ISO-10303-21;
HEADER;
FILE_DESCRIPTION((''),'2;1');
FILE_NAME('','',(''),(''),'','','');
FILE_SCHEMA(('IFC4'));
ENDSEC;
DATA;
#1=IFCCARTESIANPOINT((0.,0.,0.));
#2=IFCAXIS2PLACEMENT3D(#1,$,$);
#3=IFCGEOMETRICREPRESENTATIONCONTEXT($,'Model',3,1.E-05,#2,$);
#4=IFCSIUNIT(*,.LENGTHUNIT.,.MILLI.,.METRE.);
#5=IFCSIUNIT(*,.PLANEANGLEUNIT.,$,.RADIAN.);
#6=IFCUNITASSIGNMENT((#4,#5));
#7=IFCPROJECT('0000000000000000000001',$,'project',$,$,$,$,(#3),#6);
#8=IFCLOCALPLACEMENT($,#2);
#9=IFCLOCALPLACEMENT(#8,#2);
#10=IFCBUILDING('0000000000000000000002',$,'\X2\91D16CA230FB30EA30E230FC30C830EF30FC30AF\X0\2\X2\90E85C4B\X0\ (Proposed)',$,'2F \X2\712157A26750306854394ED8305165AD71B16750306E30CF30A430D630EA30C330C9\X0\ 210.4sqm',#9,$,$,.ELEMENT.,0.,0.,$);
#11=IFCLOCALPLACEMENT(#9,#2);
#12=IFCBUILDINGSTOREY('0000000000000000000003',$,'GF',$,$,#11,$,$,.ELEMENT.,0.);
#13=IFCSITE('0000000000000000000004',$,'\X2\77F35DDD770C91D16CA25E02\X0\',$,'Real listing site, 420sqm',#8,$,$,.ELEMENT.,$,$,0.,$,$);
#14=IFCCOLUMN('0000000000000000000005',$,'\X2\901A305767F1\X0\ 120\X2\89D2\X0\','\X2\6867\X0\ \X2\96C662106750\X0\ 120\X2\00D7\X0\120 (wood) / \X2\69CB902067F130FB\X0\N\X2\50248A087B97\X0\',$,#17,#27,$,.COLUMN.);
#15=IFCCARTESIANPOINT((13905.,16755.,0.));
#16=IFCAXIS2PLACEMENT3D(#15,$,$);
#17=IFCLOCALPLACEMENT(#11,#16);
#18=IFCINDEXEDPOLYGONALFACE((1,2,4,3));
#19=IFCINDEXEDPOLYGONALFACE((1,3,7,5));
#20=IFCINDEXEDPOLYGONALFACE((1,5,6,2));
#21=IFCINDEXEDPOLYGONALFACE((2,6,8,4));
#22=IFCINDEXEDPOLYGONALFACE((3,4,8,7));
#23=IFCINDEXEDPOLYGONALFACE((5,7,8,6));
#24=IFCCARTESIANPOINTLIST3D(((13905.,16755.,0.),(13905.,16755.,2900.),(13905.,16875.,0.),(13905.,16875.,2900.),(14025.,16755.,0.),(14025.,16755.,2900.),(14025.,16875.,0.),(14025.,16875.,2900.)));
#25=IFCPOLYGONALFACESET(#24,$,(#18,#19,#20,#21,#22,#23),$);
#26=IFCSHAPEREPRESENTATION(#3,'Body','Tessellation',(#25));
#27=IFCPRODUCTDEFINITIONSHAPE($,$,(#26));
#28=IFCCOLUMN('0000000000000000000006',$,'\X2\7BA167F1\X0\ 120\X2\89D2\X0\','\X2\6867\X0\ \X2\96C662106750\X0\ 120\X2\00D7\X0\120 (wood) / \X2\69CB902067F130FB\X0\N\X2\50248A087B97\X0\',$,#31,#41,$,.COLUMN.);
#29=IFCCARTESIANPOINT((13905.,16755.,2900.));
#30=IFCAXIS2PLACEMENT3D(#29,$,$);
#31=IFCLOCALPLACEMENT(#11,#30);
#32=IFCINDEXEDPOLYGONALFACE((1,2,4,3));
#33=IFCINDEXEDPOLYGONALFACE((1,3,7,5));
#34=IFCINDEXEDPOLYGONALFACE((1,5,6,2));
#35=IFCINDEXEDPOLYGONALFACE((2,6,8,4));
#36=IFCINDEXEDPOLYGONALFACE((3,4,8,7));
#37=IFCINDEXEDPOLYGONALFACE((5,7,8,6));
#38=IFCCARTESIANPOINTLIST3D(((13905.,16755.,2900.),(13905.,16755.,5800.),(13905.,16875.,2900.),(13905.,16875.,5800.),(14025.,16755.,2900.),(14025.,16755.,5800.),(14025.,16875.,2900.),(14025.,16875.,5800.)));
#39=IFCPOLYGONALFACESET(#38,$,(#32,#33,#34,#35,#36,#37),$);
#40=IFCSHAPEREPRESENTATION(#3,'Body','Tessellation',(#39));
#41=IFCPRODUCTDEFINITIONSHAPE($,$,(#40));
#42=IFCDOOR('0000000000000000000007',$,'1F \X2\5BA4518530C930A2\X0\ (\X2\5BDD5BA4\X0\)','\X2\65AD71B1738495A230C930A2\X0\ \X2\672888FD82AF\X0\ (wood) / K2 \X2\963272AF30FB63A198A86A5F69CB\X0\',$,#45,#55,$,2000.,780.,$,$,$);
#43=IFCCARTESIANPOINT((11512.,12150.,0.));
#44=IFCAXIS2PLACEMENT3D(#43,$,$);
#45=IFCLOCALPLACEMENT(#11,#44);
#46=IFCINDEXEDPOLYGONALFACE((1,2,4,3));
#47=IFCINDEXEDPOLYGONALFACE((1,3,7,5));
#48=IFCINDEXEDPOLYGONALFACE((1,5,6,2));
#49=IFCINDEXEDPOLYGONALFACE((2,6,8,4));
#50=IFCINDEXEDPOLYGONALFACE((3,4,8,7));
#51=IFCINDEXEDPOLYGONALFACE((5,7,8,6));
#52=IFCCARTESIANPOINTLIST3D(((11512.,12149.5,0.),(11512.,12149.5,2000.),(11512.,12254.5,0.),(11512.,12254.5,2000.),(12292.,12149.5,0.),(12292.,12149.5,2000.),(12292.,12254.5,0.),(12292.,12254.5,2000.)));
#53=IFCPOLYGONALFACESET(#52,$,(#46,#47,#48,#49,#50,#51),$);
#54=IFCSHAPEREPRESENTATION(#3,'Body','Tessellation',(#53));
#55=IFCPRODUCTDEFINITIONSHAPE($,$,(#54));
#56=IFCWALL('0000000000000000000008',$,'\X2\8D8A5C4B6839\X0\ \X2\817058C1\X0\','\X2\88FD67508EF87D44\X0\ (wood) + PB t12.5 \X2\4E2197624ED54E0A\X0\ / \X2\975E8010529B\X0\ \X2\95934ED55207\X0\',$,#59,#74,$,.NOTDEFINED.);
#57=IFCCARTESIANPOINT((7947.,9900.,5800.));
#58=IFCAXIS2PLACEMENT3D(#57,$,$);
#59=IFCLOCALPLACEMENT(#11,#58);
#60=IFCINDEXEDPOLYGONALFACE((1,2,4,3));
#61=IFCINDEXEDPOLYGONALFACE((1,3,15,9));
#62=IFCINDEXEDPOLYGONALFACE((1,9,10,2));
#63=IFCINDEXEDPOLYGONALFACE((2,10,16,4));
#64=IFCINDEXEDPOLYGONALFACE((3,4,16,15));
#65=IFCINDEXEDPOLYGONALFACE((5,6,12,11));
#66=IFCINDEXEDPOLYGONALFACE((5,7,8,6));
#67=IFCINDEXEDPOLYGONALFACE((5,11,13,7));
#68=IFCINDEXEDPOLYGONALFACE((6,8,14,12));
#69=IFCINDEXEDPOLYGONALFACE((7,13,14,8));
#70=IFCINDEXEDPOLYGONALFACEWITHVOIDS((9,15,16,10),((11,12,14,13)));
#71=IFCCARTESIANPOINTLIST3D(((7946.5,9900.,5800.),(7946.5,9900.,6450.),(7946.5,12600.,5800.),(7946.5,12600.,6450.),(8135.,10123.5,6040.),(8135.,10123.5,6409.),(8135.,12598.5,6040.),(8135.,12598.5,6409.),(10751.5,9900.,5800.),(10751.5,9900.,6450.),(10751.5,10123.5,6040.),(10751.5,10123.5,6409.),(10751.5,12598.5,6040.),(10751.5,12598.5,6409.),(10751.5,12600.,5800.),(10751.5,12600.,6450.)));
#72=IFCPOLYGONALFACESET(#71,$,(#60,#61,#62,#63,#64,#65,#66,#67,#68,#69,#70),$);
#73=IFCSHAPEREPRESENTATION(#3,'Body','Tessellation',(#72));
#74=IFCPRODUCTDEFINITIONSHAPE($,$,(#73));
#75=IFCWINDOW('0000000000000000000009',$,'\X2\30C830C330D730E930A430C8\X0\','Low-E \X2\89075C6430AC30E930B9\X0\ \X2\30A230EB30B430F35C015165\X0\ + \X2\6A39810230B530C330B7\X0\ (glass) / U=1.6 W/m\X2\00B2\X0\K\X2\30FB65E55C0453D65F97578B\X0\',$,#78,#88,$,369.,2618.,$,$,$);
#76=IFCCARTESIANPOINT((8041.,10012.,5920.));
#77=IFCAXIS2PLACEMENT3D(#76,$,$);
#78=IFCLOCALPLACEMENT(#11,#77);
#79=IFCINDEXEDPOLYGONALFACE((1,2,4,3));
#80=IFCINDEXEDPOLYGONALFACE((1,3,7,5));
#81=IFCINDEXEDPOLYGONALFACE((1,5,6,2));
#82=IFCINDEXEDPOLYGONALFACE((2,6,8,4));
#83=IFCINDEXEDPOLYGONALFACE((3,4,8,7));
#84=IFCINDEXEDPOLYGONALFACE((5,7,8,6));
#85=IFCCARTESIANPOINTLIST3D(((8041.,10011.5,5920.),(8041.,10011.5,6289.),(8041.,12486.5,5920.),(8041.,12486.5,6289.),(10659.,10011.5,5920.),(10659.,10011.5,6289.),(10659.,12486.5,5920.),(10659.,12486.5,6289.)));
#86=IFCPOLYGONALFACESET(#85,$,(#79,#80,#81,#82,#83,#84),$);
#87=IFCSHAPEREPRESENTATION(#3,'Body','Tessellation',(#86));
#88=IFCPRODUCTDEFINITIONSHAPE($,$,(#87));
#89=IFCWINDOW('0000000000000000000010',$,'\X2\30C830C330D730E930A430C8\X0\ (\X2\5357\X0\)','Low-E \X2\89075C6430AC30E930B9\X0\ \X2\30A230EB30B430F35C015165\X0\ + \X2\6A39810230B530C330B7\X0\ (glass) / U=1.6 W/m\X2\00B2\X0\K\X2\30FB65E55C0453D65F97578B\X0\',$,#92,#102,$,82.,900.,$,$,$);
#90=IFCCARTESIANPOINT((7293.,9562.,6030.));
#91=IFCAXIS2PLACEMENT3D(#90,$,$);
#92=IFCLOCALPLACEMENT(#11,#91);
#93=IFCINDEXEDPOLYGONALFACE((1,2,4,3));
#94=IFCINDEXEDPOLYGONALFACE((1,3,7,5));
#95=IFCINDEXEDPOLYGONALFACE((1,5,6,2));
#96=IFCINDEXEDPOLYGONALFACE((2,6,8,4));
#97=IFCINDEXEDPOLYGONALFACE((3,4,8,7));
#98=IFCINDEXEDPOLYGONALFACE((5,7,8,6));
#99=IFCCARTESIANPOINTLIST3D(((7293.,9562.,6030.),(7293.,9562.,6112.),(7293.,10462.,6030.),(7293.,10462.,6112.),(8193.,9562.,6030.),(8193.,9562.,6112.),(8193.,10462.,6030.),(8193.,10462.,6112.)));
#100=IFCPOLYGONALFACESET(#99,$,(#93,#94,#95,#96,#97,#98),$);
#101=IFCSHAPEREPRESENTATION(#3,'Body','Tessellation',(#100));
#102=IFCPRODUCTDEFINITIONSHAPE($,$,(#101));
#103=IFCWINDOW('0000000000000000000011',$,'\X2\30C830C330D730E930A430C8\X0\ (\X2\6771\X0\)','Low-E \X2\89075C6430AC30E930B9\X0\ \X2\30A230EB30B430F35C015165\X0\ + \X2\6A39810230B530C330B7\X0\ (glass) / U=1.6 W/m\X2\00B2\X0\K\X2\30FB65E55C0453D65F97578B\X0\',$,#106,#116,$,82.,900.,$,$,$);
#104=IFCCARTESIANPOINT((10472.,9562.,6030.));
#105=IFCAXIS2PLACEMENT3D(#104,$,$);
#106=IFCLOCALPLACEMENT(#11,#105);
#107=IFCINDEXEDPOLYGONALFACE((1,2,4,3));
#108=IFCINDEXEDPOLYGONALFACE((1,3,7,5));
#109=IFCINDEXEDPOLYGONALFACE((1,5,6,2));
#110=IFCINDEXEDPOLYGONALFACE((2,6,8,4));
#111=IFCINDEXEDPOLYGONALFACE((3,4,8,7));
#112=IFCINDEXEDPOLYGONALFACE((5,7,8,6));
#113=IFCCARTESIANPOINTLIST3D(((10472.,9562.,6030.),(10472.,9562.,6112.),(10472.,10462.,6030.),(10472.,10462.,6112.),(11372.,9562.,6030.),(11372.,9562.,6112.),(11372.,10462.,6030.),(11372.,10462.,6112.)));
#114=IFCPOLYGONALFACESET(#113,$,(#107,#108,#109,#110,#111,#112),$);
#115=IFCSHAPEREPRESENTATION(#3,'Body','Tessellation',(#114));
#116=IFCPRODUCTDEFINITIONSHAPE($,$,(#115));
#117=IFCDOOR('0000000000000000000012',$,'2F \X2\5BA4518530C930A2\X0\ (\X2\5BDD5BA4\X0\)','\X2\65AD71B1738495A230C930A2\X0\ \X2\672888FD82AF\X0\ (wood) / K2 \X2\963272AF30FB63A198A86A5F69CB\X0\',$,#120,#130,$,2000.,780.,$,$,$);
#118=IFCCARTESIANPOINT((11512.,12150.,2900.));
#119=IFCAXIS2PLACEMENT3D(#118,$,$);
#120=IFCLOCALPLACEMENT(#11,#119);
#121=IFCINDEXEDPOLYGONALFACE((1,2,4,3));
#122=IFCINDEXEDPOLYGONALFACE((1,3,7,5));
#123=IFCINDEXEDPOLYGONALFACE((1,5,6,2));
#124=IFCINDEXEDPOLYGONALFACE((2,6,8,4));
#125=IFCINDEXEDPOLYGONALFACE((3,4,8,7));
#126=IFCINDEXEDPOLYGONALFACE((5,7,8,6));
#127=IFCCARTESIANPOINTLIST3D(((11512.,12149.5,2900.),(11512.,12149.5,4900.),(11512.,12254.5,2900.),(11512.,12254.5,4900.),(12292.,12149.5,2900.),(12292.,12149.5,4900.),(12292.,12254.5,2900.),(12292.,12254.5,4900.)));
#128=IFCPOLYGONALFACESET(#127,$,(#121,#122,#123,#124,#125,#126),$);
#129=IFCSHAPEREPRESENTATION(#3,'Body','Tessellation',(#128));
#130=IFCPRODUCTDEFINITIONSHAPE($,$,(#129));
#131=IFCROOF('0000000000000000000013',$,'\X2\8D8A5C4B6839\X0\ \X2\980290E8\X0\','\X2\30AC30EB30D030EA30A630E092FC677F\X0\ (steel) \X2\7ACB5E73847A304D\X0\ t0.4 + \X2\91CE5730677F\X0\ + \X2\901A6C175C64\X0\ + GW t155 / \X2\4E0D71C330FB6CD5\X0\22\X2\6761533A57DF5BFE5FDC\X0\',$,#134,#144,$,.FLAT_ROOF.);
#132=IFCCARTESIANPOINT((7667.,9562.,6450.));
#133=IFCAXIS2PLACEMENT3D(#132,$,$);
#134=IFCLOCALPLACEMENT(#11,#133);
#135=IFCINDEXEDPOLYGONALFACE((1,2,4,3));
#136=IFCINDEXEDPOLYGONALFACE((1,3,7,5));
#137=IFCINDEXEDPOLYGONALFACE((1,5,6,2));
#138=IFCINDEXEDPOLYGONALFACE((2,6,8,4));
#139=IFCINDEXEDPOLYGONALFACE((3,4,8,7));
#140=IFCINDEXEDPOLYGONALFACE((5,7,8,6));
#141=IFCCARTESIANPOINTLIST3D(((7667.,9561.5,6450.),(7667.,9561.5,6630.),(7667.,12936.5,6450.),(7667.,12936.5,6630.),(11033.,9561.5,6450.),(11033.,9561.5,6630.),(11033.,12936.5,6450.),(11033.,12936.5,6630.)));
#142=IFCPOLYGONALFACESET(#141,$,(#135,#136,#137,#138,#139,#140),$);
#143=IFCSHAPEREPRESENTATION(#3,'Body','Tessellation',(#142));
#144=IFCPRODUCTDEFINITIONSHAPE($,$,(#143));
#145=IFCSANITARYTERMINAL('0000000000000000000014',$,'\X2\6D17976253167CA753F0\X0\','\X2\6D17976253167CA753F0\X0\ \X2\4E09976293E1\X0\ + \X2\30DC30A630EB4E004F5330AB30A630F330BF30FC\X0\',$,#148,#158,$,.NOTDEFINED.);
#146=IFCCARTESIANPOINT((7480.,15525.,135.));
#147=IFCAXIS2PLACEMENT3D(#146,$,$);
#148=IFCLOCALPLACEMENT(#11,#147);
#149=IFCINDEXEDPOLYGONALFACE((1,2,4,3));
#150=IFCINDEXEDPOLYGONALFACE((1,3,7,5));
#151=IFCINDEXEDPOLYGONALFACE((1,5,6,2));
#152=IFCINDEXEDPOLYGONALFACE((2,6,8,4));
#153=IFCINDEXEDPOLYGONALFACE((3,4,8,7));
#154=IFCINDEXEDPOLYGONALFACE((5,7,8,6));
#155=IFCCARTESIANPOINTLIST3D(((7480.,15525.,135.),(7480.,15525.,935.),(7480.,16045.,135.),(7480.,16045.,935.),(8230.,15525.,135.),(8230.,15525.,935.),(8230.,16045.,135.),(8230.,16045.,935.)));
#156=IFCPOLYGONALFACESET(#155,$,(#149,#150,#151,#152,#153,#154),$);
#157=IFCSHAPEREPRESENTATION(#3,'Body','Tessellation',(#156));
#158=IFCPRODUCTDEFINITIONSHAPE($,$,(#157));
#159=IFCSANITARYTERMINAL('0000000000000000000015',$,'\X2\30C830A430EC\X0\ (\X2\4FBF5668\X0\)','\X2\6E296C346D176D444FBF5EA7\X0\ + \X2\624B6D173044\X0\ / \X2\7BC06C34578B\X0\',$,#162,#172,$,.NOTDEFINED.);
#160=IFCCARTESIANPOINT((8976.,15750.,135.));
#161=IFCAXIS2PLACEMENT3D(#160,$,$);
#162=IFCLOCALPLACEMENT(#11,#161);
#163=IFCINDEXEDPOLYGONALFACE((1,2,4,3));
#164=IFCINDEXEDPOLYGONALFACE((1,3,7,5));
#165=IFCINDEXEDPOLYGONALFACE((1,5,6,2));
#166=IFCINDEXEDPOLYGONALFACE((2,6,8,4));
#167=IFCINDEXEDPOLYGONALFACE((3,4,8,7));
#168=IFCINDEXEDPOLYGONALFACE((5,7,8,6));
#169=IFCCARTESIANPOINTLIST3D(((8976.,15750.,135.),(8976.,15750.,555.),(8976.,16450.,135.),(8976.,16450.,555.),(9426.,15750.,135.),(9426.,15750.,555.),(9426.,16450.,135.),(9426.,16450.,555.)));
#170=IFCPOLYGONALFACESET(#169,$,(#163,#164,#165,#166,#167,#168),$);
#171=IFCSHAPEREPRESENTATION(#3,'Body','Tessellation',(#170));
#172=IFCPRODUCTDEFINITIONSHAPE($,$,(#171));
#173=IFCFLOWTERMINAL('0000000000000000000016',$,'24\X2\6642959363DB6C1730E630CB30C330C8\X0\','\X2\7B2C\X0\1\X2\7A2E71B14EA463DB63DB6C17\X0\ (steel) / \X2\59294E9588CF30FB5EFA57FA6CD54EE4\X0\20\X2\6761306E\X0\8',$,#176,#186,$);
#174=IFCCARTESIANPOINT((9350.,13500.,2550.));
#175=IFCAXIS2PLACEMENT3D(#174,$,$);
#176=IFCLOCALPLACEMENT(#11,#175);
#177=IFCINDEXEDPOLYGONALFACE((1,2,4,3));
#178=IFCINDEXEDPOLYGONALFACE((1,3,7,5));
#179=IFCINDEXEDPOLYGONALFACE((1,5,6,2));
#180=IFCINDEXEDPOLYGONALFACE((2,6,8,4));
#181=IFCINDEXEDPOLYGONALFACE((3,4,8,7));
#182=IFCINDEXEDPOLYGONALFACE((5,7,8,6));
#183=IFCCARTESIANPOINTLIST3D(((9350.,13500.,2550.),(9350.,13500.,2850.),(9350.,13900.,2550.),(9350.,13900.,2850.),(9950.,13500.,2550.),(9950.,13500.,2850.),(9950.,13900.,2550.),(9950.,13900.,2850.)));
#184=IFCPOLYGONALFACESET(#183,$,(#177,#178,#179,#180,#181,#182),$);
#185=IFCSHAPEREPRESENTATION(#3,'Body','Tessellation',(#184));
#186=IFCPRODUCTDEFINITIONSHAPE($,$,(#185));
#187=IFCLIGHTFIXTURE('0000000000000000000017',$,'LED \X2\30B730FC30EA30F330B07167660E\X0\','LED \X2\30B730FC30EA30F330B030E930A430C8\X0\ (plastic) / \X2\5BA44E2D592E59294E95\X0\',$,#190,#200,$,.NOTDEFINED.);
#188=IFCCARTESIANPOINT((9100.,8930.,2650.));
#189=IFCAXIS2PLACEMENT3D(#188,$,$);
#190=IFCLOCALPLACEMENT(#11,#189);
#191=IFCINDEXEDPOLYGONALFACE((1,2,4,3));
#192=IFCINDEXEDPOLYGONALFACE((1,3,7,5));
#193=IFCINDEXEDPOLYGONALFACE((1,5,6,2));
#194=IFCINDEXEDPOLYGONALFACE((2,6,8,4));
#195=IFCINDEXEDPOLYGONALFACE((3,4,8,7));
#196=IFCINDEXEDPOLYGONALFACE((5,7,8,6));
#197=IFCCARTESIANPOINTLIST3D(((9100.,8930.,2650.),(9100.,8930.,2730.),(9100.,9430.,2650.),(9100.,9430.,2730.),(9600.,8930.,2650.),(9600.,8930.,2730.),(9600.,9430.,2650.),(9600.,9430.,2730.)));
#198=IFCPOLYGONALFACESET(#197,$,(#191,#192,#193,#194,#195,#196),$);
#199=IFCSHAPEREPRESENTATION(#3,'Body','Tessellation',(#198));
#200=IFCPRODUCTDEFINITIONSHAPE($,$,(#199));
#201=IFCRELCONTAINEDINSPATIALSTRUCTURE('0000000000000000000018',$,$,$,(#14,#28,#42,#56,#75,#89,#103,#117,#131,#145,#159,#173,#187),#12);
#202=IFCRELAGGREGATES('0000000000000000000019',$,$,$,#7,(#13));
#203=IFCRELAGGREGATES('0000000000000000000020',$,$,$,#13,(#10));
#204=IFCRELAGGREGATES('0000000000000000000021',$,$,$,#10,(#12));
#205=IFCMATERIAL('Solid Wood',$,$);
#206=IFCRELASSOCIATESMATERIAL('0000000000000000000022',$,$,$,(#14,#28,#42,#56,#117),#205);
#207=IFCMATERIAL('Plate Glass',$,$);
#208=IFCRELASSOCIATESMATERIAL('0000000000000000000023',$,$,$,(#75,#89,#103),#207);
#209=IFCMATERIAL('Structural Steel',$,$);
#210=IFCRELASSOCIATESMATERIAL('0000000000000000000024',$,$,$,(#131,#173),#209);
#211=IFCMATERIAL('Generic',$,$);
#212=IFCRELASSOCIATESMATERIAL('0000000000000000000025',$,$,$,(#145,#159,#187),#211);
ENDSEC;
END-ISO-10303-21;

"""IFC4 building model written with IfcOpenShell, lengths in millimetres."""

from ifc_helpers import new_model, si_unit, frame, frame_2d, origin, place, context, project, spatial, rectangle, extrude, material, element, fill, save


model = new_model("IFC4")

# Units and contexts
model_context = context("Model", 3, precision=1e-05, world=origin())
ifc_project = project(units=[si_unit("LENGTHUNIT", "METRE", prefix="MILLI"), si_unit("PLANEANGLEUNIT", "RADIAN")], contexts=[model_context])

# Site, building, storey
site_placement = place(None, origin())
site = spatial("IfcSite", under=ifc_project, at=site_placement, Name="石川県金沢市", ObjectType="Real listing site, 420sqm", CompositionType="ELEMENT", RefElevation=0.0)
building_placement = place(site_placement, origin())
building = spatial("IfcBuilding", under=site, at=building_placement, Name="金沢・リモートワーク2部屋 (Proposed)", ObjectType="2F 無垢材と吹付け断熱材のハイブリッド 210.4sqm", CompositionType="ELEMENT", ElevationOfRefHeight=0.0, ElevationOfTerrain=0.0)
storey_placement = place(building_placement, origin())
storey = spatial("IfcBuildingStorey", under=building, at=storey_placement, Name="GF", CompositionType="ELEMENT", Elevation=0.0)

# Columns
ifc_material_1 = material(Name="Solid Wood")
column_1_placement = place(storey_placement, frame((13905.0, 16755.0, 0.0)))
element("IfcColumn", 1, at=column_1_placement, inside=storey, material=ifc_material_1, Name="通し柱 120角", Description="桧 集成材 120×120 (wood) / 構造柱・N値計算", PredefinedType="COLUMN", context=model_context, shape_type="SweptSolid", body=[
    extrude(rectangle(XDim=120.0, YDim=120.0, at=frame_2d((60.0, 60.0))), frame((13905.0, 16755.0, 0.0)), (0.0, 0.0, 1.0), 2900.0),
])
column_2_placement = place(storey_placement, frame((13905.0, 16755.0, 2900.0)))
element("IfcColumn", 2, at=column_2_placement, inside=storey, material=ifc_material_1, Name="管柱 120角", Description="桧 集成材 120×120 (wood) / 構造柱・N値計算", PredefinedType="COLUMN", context=model_context, shape_type="SweptSolid", body=[
    extrude(rectangle(XDim=120.0, YDim=120.0, at=frame_2d((60.0, 60.0))), frame((13905.0, 16755.0, 2900.0)), (0.0, 0.0, 1.0), 2900.0),
])

# Door
door_1_placement = place(storey_placement, frame((11512.0, 12150.0, 0.0)))
element("IfcDoor", 3, at=door_1_placement, inside=storey, material=ifc_material_1, Name="1F 室内ドア (寝室)", Description="断熱玄関ドア 木製芯 (wood) / K2 防犯・採風機構", OverallHeight=2000.0, OverallWidth=780.0, context=model_context, shape_type="SweptSolid", body=[
    extrude(rectangle(XDim=780.0, YDim=105.0, at=frame_2d((390.0, 52.0))), frame((11512.0, 12150.0, 0.0)), (0.0, 0.0, 1.0), 2000.0),
])

# Wall, openings, windows
wall_1_placement = place(storey_placement, frame((7947.0, 9900.0, 5800.0)))
wall_1 = element("IfcWall", 4, at=wall_1_placement, inside=storey, material=ifc_material_1, Name="越屋根 腰壁", Description="製材軸組 (wood) + PB t12.5 両面仕上 / 非耐力 間仕切", PredefinedType="NOTDEFINED", context=model_context, shape_type="SweptSolid", body=[
    extrude(rectangle(XDim=2805.0, YDim=2700.0, at=frame_2d((1402.0, 1350.0))), frame((7947.0, 9900.0, 5800.0)), (0.0, 0.0, 1.0), 650.0),
])
opening_1_placement = place(storey_placement, frame((8041.0, 10012.0, 5920.0)))
opening_1 = element("IfcOpeningElement", 5, at=opening_1_placement, cuts=wall_1, PredefinedType="NOTDEFINED", context=model_context, shape_type="SweptSolid", body=[
    extrude(rectangle(XDim=2618.0, YDim=2475.0, at=frame_2d((1309.0, 1237.0))), frame((8041.0, 10012.0, 5920.0)), (0.0, 0.0, 1.0), 369.0),
])
opening_2_placement = place(storey_placement, frame((7293.0, 9562.0, 6030.0)))
opening_2 = element("IfcOpeningElement", 6, at=opening_2_placement, cuts=wall_1, PredefinedType="NOTDEFINED", context=model_context, shape_type="SweptSolid", body=[
    extrude(rectangle(XDim=900.0, YDim=900.0, at=frame_2d((450.0, 450.0))), frame((7293.0, 9562.0, 6030.0)), (0.0, 0.0, 1.0), 82.0),
])
opening_3_placement = place(storey_placement, frame((10472.0, 9562.0, 6030.0)))
opening_3 = element("IfcOpeningElement", 7, at=opening_3_placement, cuts=wall_1, PredefinedType="NOTDEFINED", context=model_context, shape_type="SweptSolid", body=[
    extrude(rectangle(XDim=900.0, YDim=900.0, at=frame_2d((450.0, 450.0))), frame((10472.0, 9562.0, 6030.0)), (0.0, 0.0, 1.0), 82.0),
])
ifc_material_2 = material(Name="Plate Glass")
window_1_placement = place(storey_placement, frame((8041.0, 10012.0, 5920.0)))
window_1 = element("IfcWindow", 8, at=window_1_placement, inside=storey, material=ifc_material_2, Name="トップライト", Description="Low-E 複層ガラス アルゴン封入 + 樹脂サッシ (glass) / U=1.6 W/m²K・日射取得型", OverallHeight=369.0, OverallWidth=2618.0, context=model_context, shape_type="SweptSolid", body=[
    extrude(rectangle(XDim=2618.0, YDim=2475.0, at=frame_2d((1309.0, 1237.0))), frame((8041.0, 10012.0, 5920.0)), (0.0, 0.0, 1.0), 369.0),
])
fill(opening_1, window_1)
window_2_placement = place(storey_placement, frame((7293.0, 9562.0, 6030.0)))
window_2 = element("IfcWindow", 9, at=window_2_placement, inside=storey, material=ifc_material_2, Name="トップライト (南)", Description="Low-E 複層ガラス アルゴン封入 + 樹脂サッシ (glass) / U=1.6 W/m²K・日射取得型", OverallHeight=82.0, OverallWidth=900.0, context=model_context, shape_type="SweptSolid", body=[
    extrude(rectangle(XDim=900.0, YDim=900.0, at=frame_2d((450.0, 450.0))), frame((7293.0, 9562.0, 6030.0)), (0.0, 0.0, 1.0), 82.0),
])
fill(opening_2, window_2)
window_3_placement = place(storey_placement, frame((10472.0, 9562.0, 6030.0)))
window_3 = element("IfcWindow", 10, at=window_3_placement, inside=storey, material=ifc_material_2, Name="トップライト (東)", Description="Low-E 複層ガラス アルゴン封入 + 樹脂サッシ (glass) / U=1.6 W/m²K・日射取得型", OverallHeight=82.0, OverallWidth=900.0, context=model_context, shape_type="SweptSolid", body=[
    extrude(rectangle(XDim=900.0, YDim=900.0, at=frame_2d((450.0, 450.0))), frame((10472.0, 9562.0, 6030.0)), (0.0, 0.0, 1.0), 82.0),
])
fill(opening_3, window_3)

# Door
door_2_placement = place(storey_placement, frame((11512.0, 12150.0, 2900.0)))
element("IfcDoor", 11, at=door_2_placement, inside=storey, material=ifc_material_1, Name="2F 室内ドア (寝室)", Description="断熱玄関ドア 木製芯 (wood) / K2 防犯・採風機構", OverallHeight=2000.0, OverallWidth=780.0, context=model_context, shape_type="SweptSolid", body=[
    extrude(rectangle(XDim=780.0, YDim=105.0, at=frame_2d((390.0, 52.0))), frame((11512.0, 12150.0, 2900.0)), (0.0, 0.0, 1.0), 2000.0),
])

# Roof
ifc_material_3 = material(Name="Structural Steel")
roof_placement = place(storey_placement, frame((7667.0, 9562.0, 6450.0)))
element("IfcRoof", 12, at=roof_placement, inside=storey, material=ifc_material_3, Name="越屋根 頂部", Description="ガルバリウム鋼板 (steel) 立平葺き t0.4 + 野地板 + 通気層 + GW t155 / 不燃・法22条区域対応", PredefinedType="FLAT_ROOF", context=model_context, shape_type="SweptSolid", body=[
    extrude(rectangle(XDim=3366.0, YDim=3375.0, at=frame_2d((1683.0, 1687.0))), frame((7667.0, 9562.0, 6450.0)), (0.0, 0.0, 1.0), 180.0),
])

# Sanitary terminals
ifc_material_4 = material(Name="Generic")
sanitary_terminal_1_placement = place(storey_placement, frame((7480.0, 15525.0, 135.0)))
element("IfcSanitaryTerminal", 13, at=sanitary_terminal_1_placement, inside=storey, material=ifc_material_4, Name="洗面化粧台", Description="洗面化粧台 三面鏡 + ボウル一体カウンター", PredefinedType="NOTDEFINED", context=model_context, shape_type="SweptSolid", body=[
    extrude(rectangle(XDim=750.0, YDim=520.0, at=frame_2d((375.0, 260.0))), frame((7480.0, 15525.0, 135.0)), (0.0, 0.0, 1.0), 800.0),
])
sanitary_terminal_2_placement = place(storey_placement, frame((8976.0, 15750.0, 135.0)))
element("IfcSanitaryTerminal", 14, at=sanitary_terminal_2_placement, inside=storey, material=ifc_material_4, Name="トイレ (便器)", Description="温水洗浄便座 + 手洗い / 節水型", PredefinedType="NOTDEFINED", context=model_context, shape_type="SweptSolid", body=[
    extrude(rectangle(XDim=450.0, YDim=700.0, at=frame_2d((225.0, 350.0))), frame((8976.0, 15750.0, 135.0)), (0.0, 0.0, 1.0), 420.0),
])

# Flow terminal
flow_terminal_placement = place(storey_placement, frame((9350.0, 13500.0, 2550.0)))
element("IfcFlowTerminal", 15, at=flow_terminal_placement, inside=storey, material=ifc_material_3, Name="24時間換気ユニット", Description="第1種熱交換換気 (steel) / 天井裏・建基法令20条の8", context=model_context, shape_type="SweptSolid", body=[
    extrude(rectangle(XDim=600.0, YDim=400.0, at=frame_2d((300.0, 200.0))), frame((9350.0, 13500.0, 2550.0)), (0.0, 0.0, 1.0), 300.0),
])

# Light fixture
light_fixture_1_placement = place(storey_placement, frame((9100.0, 8930.0, 2650.0)))
element("IfcLightFixture", 16, at=light_fixture_1_placement, inside=storey, material=ifc_material_4, Name="LED シーリング照明", Description="LED シーリングライト (plastic) / 室中央天井", PredefinedType="NOTDEFINED", context=model_context, shape_type="SweptSolid", body=[
    extrude(rectangle(XDim=500.0, YDim=500.0, at=frame_2d((250.0, 250.0))), frame((9100.0, 8930.0, 2650.0)), (0.0, 0.0, 1.0), 80.0),
])

save(model, "model.ifc")
